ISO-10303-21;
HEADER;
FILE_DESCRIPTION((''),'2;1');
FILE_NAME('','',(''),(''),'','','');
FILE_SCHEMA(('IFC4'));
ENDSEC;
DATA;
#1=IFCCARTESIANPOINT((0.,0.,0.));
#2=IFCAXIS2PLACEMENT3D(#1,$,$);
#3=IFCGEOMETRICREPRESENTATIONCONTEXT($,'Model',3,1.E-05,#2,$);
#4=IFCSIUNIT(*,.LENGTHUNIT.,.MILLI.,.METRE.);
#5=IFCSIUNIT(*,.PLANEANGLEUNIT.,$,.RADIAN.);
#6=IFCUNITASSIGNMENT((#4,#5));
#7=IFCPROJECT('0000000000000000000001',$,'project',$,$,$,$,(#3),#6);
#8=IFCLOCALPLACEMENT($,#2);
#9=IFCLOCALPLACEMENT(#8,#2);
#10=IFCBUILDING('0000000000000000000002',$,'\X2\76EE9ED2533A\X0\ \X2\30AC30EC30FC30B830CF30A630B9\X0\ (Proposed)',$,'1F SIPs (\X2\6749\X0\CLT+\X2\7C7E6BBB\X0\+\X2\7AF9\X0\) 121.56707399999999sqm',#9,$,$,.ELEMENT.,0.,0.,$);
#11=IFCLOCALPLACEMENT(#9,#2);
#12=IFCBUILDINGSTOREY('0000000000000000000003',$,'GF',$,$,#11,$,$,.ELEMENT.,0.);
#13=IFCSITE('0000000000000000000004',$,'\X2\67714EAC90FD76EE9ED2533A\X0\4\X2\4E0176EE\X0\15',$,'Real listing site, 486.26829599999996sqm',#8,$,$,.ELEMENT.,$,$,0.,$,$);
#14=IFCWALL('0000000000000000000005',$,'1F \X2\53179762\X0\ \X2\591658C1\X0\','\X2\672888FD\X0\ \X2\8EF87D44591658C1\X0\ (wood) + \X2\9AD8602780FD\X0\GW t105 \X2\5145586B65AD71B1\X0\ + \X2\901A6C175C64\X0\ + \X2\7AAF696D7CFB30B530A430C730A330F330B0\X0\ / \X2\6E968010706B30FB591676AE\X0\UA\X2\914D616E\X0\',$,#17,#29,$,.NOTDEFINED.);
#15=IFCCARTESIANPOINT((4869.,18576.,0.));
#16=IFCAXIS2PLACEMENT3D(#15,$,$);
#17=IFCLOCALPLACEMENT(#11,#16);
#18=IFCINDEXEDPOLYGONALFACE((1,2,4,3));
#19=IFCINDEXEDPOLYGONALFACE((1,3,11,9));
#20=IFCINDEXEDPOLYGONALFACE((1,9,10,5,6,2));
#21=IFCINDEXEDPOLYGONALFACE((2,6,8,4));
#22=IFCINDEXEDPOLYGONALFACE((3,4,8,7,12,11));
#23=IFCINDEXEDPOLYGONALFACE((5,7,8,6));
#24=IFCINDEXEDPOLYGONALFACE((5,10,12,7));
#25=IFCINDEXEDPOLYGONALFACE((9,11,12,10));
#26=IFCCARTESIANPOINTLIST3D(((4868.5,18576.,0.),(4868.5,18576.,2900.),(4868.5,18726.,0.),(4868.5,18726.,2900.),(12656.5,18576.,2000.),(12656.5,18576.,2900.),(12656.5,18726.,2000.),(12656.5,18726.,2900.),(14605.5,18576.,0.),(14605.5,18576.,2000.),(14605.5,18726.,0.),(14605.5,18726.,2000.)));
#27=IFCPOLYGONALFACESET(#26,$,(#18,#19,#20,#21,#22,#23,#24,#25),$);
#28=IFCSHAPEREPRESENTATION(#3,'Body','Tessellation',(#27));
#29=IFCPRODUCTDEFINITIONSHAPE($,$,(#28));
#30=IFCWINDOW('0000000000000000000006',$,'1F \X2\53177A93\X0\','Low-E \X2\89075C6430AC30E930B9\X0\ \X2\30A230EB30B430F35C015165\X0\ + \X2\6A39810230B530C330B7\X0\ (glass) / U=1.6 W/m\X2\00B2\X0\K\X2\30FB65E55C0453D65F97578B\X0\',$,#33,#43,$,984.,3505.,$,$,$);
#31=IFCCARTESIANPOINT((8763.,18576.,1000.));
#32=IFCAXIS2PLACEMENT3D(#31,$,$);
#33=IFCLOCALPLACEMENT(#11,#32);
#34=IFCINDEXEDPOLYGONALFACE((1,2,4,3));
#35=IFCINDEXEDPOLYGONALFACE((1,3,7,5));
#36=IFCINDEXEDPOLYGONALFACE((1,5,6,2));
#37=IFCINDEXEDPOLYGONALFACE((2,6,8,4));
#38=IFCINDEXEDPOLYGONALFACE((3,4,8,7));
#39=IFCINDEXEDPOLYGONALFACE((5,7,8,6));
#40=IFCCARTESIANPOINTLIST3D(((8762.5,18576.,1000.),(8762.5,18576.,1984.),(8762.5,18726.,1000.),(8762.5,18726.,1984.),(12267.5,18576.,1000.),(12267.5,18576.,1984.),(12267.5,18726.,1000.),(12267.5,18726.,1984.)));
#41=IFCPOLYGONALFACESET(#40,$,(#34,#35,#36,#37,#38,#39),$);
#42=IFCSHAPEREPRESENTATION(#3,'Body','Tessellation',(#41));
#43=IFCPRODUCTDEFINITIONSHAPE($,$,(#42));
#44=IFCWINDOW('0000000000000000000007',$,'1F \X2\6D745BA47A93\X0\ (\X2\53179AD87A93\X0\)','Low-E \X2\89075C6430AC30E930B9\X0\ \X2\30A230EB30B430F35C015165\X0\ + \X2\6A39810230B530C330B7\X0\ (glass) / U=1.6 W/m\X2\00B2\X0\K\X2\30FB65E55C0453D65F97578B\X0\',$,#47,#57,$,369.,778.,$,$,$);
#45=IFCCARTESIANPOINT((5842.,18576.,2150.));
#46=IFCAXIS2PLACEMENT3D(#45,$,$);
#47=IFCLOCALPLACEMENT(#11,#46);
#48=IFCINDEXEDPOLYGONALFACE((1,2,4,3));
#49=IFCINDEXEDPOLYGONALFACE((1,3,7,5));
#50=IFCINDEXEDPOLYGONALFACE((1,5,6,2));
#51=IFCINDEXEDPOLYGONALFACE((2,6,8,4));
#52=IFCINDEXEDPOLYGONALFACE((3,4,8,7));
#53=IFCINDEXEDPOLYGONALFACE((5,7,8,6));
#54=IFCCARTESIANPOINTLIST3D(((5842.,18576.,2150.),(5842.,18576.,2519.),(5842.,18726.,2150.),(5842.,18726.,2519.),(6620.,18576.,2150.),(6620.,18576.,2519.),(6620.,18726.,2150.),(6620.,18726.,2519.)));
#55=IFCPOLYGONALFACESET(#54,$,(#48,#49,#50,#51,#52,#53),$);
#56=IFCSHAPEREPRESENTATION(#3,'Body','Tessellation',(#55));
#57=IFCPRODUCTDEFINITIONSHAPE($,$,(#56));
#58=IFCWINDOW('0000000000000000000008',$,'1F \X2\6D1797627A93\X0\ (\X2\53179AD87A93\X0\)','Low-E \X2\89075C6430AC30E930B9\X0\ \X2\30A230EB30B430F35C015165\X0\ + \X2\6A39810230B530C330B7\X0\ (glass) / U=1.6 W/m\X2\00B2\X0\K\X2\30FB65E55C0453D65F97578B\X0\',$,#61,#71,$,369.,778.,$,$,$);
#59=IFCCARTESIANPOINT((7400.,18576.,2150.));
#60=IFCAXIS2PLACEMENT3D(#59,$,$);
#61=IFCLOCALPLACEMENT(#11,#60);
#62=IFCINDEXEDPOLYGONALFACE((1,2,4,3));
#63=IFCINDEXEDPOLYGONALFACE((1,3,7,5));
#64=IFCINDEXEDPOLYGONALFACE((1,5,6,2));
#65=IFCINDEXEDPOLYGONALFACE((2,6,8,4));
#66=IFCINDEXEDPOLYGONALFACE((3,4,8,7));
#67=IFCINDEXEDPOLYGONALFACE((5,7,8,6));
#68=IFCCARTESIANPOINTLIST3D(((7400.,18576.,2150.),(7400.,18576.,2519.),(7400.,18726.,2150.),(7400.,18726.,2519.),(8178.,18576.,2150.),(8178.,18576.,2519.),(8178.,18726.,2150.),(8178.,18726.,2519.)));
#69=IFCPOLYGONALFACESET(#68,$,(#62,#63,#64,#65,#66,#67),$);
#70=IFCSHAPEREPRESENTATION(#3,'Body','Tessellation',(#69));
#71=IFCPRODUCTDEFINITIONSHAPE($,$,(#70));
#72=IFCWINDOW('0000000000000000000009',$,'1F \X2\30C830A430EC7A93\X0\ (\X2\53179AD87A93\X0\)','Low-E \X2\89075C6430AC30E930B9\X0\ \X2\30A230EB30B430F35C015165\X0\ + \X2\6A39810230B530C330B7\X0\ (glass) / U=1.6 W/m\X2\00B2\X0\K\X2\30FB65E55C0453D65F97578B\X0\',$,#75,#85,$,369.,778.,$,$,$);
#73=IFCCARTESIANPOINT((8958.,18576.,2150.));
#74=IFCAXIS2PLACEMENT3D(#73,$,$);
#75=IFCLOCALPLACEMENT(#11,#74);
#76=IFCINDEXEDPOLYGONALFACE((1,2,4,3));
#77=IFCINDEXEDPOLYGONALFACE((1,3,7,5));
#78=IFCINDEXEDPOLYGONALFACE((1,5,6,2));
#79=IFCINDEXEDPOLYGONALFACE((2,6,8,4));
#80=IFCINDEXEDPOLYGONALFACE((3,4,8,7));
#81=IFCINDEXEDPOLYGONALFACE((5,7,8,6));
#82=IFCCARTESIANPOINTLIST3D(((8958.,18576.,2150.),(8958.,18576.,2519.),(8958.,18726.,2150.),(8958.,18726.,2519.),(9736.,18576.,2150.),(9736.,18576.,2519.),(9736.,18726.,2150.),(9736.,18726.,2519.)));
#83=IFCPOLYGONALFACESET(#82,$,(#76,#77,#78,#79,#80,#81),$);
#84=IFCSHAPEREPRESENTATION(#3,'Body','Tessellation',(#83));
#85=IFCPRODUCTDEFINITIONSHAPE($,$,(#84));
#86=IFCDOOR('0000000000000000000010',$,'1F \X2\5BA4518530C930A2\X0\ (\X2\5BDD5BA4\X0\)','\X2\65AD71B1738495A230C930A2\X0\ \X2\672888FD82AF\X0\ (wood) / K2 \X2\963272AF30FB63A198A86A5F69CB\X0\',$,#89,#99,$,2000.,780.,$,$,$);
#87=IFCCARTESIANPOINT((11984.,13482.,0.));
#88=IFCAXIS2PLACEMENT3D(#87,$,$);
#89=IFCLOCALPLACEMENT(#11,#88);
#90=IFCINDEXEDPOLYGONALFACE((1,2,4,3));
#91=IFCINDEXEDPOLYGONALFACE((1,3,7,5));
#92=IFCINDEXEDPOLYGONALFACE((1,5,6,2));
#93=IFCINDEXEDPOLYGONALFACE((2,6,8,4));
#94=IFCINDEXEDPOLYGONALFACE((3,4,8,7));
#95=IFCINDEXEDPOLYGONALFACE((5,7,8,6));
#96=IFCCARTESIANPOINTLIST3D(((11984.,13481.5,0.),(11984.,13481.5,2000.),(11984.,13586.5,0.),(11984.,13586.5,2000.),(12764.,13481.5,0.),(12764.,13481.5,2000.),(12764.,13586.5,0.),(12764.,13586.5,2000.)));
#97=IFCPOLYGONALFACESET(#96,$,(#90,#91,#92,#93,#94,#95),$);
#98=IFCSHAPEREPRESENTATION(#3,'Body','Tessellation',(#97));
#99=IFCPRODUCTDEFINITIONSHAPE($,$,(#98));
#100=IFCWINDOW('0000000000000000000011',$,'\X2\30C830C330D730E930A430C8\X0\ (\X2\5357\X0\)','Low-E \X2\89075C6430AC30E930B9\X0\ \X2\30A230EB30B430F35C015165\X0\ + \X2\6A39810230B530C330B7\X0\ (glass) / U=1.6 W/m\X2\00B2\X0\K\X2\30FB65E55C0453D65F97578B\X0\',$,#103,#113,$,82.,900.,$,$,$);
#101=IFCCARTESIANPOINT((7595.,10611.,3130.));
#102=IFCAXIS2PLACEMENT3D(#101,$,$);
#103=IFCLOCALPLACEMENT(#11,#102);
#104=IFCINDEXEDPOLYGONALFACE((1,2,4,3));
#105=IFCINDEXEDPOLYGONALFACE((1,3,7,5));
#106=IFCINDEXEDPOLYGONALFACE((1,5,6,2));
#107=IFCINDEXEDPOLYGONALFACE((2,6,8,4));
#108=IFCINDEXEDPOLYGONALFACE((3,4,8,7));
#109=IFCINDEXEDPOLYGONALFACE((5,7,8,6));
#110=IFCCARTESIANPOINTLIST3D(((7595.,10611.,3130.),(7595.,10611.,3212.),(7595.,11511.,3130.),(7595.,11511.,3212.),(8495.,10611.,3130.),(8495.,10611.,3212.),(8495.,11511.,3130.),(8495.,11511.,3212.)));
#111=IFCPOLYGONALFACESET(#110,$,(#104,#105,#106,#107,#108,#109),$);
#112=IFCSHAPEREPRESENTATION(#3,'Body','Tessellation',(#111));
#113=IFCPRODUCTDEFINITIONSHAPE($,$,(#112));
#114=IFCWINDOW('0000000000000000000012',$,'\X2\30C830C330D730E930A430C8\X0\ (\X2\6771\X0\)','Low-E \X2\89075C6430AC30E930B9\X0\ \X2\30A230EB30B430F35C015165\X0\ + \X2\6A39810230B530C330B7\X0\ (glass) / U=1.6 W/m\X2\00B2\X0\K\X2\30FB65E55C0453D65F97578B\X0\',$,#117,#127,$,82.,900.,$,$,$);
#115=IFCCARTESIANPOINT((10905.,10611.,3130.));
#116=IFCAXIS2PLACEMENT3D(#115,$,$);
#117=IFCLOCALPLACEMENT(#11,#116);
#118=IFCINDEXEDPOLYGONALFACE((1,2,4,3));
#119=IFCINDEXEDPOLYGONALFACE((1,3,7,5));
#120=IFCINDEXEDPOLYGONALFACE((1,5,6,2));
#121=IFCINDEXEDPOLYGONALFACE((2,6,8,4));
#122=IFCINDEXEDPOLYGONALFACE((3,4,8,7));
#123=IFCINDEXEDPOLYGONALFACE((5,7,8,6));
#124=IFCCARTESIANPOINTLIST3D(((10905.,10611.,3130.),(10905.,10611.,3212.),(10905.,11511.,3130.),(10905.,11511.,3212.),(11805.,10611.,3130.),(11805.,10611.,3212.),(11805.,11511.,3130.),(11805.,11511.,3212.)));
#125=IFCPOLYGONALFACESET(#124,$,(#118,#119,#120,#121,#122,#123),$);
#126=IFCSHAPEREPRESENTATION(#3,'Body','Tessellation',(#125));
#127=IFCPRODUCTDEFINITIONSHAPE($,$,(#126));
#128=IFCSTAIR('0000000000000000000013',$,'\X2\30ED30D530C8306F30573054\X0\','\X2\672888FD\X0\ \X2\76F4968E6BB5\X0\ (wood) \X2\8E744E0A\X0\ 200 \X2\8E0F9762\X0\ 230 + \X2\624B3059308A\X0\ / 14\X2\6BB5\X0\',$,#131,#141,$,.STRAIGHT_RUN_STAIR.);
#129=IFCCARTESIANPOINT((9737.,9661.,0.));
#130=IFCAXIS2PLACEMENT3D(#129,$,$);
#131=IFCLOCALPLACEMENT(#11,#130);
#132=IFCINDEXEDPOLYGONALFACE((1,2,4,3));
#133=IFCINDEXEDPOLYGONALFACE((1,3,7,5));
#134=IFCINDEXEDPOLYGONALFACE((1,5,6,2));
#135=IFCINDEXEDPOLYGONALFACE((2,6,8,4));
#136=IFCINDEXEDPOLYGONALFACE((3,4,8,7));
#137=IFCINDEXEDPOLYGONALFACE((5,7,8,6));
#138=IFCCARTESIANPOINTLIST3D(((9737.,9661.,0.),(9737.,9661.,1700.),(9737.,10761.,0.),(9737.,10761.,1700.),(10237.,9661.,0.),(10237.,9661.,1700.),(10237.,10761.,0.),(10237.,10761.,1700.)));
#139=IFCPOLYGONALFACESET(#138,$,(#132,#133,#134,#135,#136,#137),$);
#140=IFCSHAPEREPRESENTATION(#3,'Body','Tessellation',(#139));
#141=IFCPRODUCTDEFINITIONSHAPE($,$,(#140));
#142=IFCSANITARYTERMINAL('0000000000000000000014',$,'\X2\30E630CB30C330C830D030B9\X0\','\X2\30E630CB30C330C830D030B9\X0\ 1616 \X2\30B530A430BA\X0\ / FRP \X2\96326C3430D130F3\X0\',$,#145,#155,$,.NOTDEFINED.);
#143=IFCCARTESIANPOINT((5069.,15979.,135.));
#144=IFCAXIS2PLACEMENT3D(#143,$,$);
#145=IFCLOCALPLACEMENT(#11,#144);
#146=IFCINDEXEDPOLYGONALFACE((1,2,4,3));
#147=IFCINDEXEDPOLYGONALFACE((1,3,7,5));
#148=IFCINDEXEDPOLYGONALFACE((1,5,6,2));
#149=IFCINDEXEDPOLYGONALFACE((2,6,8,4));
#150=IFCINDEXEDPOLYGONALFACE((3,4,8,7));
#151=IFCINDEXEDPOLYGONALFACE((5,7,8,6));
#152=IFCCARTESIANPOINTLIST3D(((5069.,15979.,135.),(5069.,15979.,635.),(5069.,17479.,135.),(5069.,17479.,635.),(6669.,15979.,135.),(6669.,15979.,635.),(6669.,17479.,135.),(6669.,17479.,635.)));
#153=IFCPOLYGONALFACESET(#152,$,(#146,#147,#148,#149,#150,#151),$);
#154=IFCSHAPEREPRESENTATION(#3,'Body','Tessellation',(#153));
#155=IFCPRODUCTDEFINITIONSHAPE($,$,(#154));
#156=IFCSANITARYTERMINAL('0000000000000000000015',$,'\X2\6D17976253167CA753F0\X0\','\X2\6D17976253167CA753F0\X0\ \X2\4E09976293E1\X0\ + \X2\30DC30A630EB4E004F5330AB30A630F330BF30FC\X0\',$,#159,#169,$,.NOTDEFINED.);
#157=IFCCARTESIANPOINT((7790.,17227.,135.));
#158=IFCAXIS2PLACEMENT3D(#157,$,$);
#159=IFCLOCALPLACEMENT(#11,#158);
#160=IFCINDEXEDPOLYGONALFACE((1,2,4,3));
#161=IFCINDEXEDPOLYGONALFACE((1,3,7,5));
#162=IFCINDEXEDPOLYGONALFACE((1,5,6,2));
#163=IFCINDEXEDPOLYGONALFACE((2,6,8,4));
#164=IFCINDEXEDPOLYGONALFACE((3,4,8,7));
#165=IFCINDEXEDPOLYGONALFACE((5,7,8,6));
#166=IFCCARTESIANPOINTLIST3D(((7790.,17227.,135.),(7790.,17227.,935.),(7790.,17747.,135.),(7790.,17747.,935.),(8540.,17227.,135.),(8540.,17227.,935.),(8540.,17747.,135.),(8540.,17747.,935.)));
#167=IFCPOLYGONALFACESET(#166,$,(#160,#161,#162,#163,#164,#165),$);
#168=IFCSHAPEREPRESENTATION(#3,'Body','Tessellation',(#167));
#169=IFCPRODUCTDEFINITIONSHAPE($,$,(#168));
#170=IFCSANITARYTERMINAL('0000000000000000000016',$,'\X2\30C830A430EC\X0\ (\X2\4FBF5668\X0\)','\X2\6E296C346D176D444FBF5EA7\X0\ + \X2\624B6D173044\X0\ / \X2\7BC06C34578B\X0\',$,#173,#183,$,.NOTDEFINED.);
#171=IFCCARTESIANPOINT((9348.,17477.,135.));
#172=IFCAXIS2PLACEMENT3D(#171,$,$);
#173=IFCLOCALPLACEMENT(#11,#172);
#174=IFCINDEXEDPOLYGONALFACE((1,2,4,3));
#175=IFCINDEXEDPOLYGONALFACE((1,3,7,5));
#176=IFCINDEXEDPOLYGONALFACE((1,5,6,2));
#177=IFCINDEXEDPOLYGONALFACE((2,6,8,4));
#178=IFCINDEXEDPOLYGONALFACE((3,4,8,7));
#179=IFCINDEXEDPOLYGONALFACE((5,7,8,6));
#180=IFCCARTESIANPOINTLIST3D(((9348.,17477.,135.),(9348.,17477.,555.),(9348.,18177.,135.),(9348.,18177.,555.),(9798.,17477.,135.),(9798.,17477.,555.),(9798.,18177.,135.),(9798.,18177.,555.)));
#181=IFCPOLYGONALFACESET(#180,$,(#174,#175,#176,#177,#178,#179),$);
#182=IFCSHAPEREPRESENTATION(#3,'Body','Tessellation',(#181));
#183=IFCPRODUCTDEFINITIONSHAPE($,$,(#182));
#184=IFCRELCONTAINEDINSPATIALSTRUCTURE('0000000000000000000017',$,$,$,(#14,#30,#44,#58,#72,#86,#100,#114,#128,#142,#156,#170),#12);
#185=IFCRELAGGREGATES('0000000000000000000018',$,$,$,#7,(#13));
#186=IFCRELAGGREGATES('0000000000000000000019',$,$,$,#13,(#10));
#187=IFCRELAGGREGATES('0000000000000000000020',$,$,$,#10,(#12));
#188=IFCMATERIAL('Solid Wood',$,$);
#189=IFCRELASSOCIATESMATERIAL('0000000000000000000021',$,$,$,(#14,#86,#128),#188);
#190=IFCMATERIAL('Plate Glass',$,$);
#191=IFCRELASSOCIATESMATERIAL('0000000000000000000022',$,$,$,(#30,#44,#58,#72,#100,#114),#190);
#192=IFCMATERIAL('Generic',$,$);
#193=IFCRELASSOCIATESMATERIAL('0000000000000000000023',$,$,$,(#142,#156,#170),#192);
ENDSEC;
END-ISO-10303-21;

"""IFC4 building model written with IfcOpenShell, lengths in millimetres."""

from ifc_helpers import new_model, si_unit, frame, frame_2d, origin, place, context, project, spatial, rectangle, extrude, material, element, fill, save


model = new_model("IFC4")

# Units and contexts
model_context = context("Model", 3, precision=1e-05, world=origin())
ifc_project = project(units=[si_unit("LENGTHUNIT", "METRE", prefix="MILLI"), si_unit("PLANEANGLEUNIT", "RADIAN")], contexts=[model_context])

# Site, building, storey
site_placement = place(None, origin())
site = spatial("IfcSite", under=ifc_project, at=site_placement, Name="東京都目黒区4丁目15", ObjectType="Real listing site, 486.26829599999996sqm", CompositionType="ELEMENT", RefElevation=0.0)
building_placement = place(site_placement, origin())
building = spatial("IfcBuilding", under=site, at=building_placement, Name="目黒区 ガレージハウス (Proposed)", ObjectType="1F SIPs (杉CLT+籾殻+竹) 121.56707399999999sqm", CompositionType="ELEMENT", ElevationOfRefHeight=0.0, ElevationOfTerrain=0.0)
storey_placement = place(building_placement, origin())
storey = spatial("IfcBuildingStorey", under=building, at=storey_placement, Name="GF", CompositionType="ELEMENT", Elevation=0.0)

# Shared definitions
ifc_material_1 = material(Name="Solid Wood")

# Wall, openings, windows
wall_1_placement = place(storey_placement, frame((4869.0, 18576.0, 0.0)))
wall_1 = element("IfcWall", 1, at=wall_1_placement, inside=storey, material=ifc_material_1, Name="1F 北面 外壁", Description="木製 軸組外壁 (wood) + 高性能GW t105 充填断熱 + 通気層 + 窯業系サイディング / 準耐火・外皮UA配慮", PredefinedType="NOTDEFINED", context=model_context, shape_type="SweptSolid", body=[
    extrude(rectangle(XDim=9737.0, YDim=150.0, at=frame_2d((4868.0, 75.0))), frame((4869.0, 18576.0, 0.0)), (0.0, 0.0, 1.0), 2900.0),
])
opening_1_placement = place(storey_placement, frame((8763.0, 18576.0, 1000.0)))
opening_1 = element("IfcOpeningElement", 2, at=opening_1_placement, cuts=wall_1, PredefinedType="NOTDEFINED", context=model_context, shape_type="SweptSolid", body=[
    extrude(rectangle(XDim=3505.0, YDim=150.0, at=frame_2d((1752.0, 75.0))), frame((8763.0, 18576.0, 1000.0)), (0.0, 0.0, 1.0), 984.0),
])
opening_2_placement = place(storey_placement, frame((5842.0, 18576.0, 2150.0)))
opening_2 = element("IfcOpeningElement", 3, at=opening_2_placement, cuts=wall_1, PredefinedType="NOTDEFINED", context=model_context, shape_type="SweptSolid", body=[
    extrude(rectangle(XDim=778.0, YDim=150.0, at=frame_2d((389.0, 75.0))), frame((5842.0, 18576.0, 2150.0)), (0.0, 0.0, 1.0), 369.0),
])
opening_3_placement = place(storey_placement, frame((7400.0, 18576.0, 2150.0)))
opening_3 = element("IfcOpeningElement", 4, at=opening_3_placement, cuts=wall_1, PredefinedType="NOTDEFINED", context=model_context, shape_type="SweptSolid", body=[
    extrude(rectangle(XDim=778.0, YDim=150.0, at=frame_2d((389.0, 75.0))), frame((7400.0, 18576.0, 2150.0)), (0.0, 0.0, 1.0), 369.0),
])
opening_4_placement = place(storey_placement, frame((8958.0, 18576.0, 2150.0)))
opening_4 = element("IfcOpeningElement", 5, at=opening_4_placement, cuts=wall_1, PredefinedType="NOTDEFINED", context=model_context, shape_type="SweptSolid", body=[
    extrude(rectangle(XDim=778.0, YDim=150.0, at=frame_2d((389.0, 75.0))), frame((8958.0, 18576.0, 2150.0)), (0.0, 0.0, 1.0), 369.0),
])
ifc_material_2 = material(Name="Plate Glass")
window_1_placement = place(storey_placement, frame((8763.0, 18576.0, 1000.0)))
window_1 = element("IfcWindow", 6, at=window_1_placement, inside=storey, material=ifc_material_2, Name="1F 北窓", Description="Low-E 複層ガラス アルゴン封入 + 樹脂サッシ (glass) / U=1.6 W/m²K・日射取得型", OverallHeight=984.0, OverallWidth=3505.0, context=model_context, shape_type="SweptSolid", body=[
    extrude(rectangle(XDim=3505.0, YDim=150.0, at=frame_2d((1752.0, 75.0))), frame((8763.0, 18576.0, 1000.0)), (0.0, 0.0, 1.0), 984.0),
])
fill(opening_1, window_1)
window_2_placement = place(storey_placement, frame((5842.0, 18576.0, 2150.0)))
window_2 = element("IfcWindow", 7, at=window_2_placement, inside=storey, material=ifc_material_2, Name="1F 浴室窓 (北高窓)", Description="Low-E 複層ガラス アルゴン封入 + 樹脂サッシ (glass) / U=1.6 W/m²K・日射取得型", OverallHeight=369.0, OverallWidth=778.0, context=model_context, shape_type="SweptSolid", body=[
    extrude(rectangle(XDim=778.0, YDim=150.0, at=frame_2d((389.0, 75.0))), frame((5842.0, 18576.0, 2150.0)), (0.0, 0.0, 1.0), 369.0),
])
fill(opening_2, window_2)
window_3_placement = place(storey_placement, frame((7400.0, 18576.0, 2150.0)))
window_3 = element("IfcWindow", 8, at=window_3_placement, inside=storey, material=ifc_material_2, Name="1F 洗面窓 (北高窓)", Description="Low-E 複層ガラス アルゴン封入 + 樹脂サッシ (glass) / U=1.6 W/m²K・日射取得型", OverallHeight=369.0, OverallWidth=778.0, context=model_context, shape_type="SweptSolid", body=[
    extrude(rectangle(XDim=778.0, YDim=150.0, at=frame_2d((389.0, 75.0))), frame((7400.0, 18576.0, 2150.0)), (0.0, 0.0, 1.0), 369.0),
])
fill(opening_3, window_3)
window_4_placement = place(storey_placement, frame((8958.0, 18576.0, 2150.0)))
window_4 = element("IfcWindow", 9, at=window_4_placement, inside=storey, material=ifc_material_2, Name="1F トイレ窓 (北高窓)", Description="Low-E 複層ガラス アルゴン封入 + 樹脂サッシ (glass) / U=1.6 W/m²K・日射取得型", OverallHeight=369.0, OverallWidth=778.0, context=model_context, shape_type="SweptSolid", body=[
    extrude(rectangle(XDim=778.0, YDim=150.0, at=frame_2d((389.0, 75.0))), frame((8958.0, 18576.0, 2150.0)), (0.0, 0.0, 1.0), 369.0),
])
fill(opening_4, window_4)

# Door
door_1_placement = place(storey_placement, frame((11984.0, 13482.0, 0.0)))
element("IfcDoor", 10, at=door_1_placement, inside=storey, material=ifc_material_1, Name="1F 室内ドア (寝室)", Description="断熱玄関ドア 木製芯 (wood) / K2 防犯・採風機構", OverallHeight=2000.0, OverallWidth=780.0, context=model_context, shape_type="SweptSolid", body=[
    extrude(rectangle(XDim=780.0, YDim=105.0, at=frame_2d((390.0, 52.0))), frame((11984.0, 13482.0, 0.0)), (0.0, 0.0, 1.0), 2000.0),
])

# Windows
window_5_placement = place(storey_placement, frame((7595.0, 10611.0, 3130.0)))
element("IfcWindow", 11, at=window_5_placement, inside=storey, material=ifc_material_2, Name="トップライト (南)", Description="Low-E 複層ガラス アルゴン封入 + 樹脂サッシ (glass) / U=1.6 W/m²K・日射取得型", OverallHeight=82.0, OverallWidth=900.0, context=model_context, shape_type="SweptSolid", body=[
    extrude(rectangle(XDim=900.0, YDim=900.0, at=frame_2d((450.0, 450.0))), frame((7595.0, 10611.0, 3130.0)), (0.0, 0.0, 1.0), 82.0),
])
window_6_placement = place(storey_placement, frame((10905.0, 10611.0, 3130.0)))
element("IfcWindow", 12, at=window_6_placement, inside=storey, material=ifc_material_2, Name="トップライト (東)", Description="Low-E 複層ガラス アルゴン封入 + 樹脂サッシ (glass) / U=1.6 W/m²K・日射取得型", OverallHeight=82.0, OverallWidth=900.0, context=model_context, shape_type="SweptSolid", body=[
    extrude(rectangle(XDim=900.0, YDim=900.0, at=frame_2d((450.0, 450.0))), frame((10905.0, 10611.0, 3130.0)), (0.0, 0.0, 1.0), 82.0),
])

# Stair
stair_placement = place(storey_placement, frame((9737.0, 9661.0, 0.0)))
element("IfcStair", 13, at=stair_placement, inside=storey, material=ifc_material_1, Name="ロフトはしご", Description="木製 直階段 (wood) 蹴上 200 踏面 230 + 手すり / 14段", PredefinedType="STRAIGHT_RUN_STAIR", context=model_context, shape_type="SweptSolid", body=[
    extrude(rectangle(XDim=500.0, YDim=1100.0, at=frame_2d((250.0, 550.0))), frame((9737.0, 9661.0, 0.0)), (0.0, 0.0, 1.0), 1700.0),
])

# Sanitary terminals
ifc_material_3 = material(Name="Generic")
sanitary_terminal_1_placement = place(storey_placement, frame((5069.0, 15979.0, 135.0)))
element("IfcSanitaryTerminal", 14, at=sanitary_terminal_1_placement, inside=storey, material=ifc_material_3, Name="ユニットバス", Description="ユニットバス 1616 サイズ / FRP 防水パン", PredefinedType="NOTDEFINED", context=model_context, shape_type="SweptSolid", body=[
    extrude(rectangle(XDim=1600.0, YDim=1500.0, at=frame_2d((800.0, 750.0))), frame((5069.0, 15979.0, 135.0)), (0.0, 0.0, 1.0), 500.0),
])
sanitary_terminal_2_placement = place(storey_placement, frame((7790.0, 17227.0, 135.0)))
element("IfcSanitaryTerminal", 15, at=sanitary_terminal_2_placement, inside=storey, material=ifc_material_3, Name="洗面化粧台", Description="洗面化粧台 三面鏡 + ボウル一体カウンター", PredefinedType="NOTDEFINED", context=model_context, shape_type="SweptSolid", body=[
    extrude(rectangle(XDim=750.0, YDim=520.0, at=frame_2d((375.0, 260.0))), frame((7790.0, 17227.0, 135.0)), (0.0, 0.0, 1.0), 800.0),
])
sanitary_terminal_3_placement = place(storey_placement, frame((9348.0, 17477.0, 135.0)))
element("IfcSanitaryTerminal", 16, at=sanitary_terminal_3_placement, inside=storey, material=ifc_material_3, Name="トイレ (便器)", Description="温水洗浄便座 + 手洗い / 節水型", PredefinedType="NOTDEFINED", context=model_context, shape_type="SweptSolid", body=[
    extrude(rectangle(XDim=450.0, YDim=700.0, at=frame_2d((225.0, 350.0))), frame((9348.0, 17477.0, 135.0)), (0.0, 0.0, 1.0), 420.0),
])

save(model, "model.ifc")
